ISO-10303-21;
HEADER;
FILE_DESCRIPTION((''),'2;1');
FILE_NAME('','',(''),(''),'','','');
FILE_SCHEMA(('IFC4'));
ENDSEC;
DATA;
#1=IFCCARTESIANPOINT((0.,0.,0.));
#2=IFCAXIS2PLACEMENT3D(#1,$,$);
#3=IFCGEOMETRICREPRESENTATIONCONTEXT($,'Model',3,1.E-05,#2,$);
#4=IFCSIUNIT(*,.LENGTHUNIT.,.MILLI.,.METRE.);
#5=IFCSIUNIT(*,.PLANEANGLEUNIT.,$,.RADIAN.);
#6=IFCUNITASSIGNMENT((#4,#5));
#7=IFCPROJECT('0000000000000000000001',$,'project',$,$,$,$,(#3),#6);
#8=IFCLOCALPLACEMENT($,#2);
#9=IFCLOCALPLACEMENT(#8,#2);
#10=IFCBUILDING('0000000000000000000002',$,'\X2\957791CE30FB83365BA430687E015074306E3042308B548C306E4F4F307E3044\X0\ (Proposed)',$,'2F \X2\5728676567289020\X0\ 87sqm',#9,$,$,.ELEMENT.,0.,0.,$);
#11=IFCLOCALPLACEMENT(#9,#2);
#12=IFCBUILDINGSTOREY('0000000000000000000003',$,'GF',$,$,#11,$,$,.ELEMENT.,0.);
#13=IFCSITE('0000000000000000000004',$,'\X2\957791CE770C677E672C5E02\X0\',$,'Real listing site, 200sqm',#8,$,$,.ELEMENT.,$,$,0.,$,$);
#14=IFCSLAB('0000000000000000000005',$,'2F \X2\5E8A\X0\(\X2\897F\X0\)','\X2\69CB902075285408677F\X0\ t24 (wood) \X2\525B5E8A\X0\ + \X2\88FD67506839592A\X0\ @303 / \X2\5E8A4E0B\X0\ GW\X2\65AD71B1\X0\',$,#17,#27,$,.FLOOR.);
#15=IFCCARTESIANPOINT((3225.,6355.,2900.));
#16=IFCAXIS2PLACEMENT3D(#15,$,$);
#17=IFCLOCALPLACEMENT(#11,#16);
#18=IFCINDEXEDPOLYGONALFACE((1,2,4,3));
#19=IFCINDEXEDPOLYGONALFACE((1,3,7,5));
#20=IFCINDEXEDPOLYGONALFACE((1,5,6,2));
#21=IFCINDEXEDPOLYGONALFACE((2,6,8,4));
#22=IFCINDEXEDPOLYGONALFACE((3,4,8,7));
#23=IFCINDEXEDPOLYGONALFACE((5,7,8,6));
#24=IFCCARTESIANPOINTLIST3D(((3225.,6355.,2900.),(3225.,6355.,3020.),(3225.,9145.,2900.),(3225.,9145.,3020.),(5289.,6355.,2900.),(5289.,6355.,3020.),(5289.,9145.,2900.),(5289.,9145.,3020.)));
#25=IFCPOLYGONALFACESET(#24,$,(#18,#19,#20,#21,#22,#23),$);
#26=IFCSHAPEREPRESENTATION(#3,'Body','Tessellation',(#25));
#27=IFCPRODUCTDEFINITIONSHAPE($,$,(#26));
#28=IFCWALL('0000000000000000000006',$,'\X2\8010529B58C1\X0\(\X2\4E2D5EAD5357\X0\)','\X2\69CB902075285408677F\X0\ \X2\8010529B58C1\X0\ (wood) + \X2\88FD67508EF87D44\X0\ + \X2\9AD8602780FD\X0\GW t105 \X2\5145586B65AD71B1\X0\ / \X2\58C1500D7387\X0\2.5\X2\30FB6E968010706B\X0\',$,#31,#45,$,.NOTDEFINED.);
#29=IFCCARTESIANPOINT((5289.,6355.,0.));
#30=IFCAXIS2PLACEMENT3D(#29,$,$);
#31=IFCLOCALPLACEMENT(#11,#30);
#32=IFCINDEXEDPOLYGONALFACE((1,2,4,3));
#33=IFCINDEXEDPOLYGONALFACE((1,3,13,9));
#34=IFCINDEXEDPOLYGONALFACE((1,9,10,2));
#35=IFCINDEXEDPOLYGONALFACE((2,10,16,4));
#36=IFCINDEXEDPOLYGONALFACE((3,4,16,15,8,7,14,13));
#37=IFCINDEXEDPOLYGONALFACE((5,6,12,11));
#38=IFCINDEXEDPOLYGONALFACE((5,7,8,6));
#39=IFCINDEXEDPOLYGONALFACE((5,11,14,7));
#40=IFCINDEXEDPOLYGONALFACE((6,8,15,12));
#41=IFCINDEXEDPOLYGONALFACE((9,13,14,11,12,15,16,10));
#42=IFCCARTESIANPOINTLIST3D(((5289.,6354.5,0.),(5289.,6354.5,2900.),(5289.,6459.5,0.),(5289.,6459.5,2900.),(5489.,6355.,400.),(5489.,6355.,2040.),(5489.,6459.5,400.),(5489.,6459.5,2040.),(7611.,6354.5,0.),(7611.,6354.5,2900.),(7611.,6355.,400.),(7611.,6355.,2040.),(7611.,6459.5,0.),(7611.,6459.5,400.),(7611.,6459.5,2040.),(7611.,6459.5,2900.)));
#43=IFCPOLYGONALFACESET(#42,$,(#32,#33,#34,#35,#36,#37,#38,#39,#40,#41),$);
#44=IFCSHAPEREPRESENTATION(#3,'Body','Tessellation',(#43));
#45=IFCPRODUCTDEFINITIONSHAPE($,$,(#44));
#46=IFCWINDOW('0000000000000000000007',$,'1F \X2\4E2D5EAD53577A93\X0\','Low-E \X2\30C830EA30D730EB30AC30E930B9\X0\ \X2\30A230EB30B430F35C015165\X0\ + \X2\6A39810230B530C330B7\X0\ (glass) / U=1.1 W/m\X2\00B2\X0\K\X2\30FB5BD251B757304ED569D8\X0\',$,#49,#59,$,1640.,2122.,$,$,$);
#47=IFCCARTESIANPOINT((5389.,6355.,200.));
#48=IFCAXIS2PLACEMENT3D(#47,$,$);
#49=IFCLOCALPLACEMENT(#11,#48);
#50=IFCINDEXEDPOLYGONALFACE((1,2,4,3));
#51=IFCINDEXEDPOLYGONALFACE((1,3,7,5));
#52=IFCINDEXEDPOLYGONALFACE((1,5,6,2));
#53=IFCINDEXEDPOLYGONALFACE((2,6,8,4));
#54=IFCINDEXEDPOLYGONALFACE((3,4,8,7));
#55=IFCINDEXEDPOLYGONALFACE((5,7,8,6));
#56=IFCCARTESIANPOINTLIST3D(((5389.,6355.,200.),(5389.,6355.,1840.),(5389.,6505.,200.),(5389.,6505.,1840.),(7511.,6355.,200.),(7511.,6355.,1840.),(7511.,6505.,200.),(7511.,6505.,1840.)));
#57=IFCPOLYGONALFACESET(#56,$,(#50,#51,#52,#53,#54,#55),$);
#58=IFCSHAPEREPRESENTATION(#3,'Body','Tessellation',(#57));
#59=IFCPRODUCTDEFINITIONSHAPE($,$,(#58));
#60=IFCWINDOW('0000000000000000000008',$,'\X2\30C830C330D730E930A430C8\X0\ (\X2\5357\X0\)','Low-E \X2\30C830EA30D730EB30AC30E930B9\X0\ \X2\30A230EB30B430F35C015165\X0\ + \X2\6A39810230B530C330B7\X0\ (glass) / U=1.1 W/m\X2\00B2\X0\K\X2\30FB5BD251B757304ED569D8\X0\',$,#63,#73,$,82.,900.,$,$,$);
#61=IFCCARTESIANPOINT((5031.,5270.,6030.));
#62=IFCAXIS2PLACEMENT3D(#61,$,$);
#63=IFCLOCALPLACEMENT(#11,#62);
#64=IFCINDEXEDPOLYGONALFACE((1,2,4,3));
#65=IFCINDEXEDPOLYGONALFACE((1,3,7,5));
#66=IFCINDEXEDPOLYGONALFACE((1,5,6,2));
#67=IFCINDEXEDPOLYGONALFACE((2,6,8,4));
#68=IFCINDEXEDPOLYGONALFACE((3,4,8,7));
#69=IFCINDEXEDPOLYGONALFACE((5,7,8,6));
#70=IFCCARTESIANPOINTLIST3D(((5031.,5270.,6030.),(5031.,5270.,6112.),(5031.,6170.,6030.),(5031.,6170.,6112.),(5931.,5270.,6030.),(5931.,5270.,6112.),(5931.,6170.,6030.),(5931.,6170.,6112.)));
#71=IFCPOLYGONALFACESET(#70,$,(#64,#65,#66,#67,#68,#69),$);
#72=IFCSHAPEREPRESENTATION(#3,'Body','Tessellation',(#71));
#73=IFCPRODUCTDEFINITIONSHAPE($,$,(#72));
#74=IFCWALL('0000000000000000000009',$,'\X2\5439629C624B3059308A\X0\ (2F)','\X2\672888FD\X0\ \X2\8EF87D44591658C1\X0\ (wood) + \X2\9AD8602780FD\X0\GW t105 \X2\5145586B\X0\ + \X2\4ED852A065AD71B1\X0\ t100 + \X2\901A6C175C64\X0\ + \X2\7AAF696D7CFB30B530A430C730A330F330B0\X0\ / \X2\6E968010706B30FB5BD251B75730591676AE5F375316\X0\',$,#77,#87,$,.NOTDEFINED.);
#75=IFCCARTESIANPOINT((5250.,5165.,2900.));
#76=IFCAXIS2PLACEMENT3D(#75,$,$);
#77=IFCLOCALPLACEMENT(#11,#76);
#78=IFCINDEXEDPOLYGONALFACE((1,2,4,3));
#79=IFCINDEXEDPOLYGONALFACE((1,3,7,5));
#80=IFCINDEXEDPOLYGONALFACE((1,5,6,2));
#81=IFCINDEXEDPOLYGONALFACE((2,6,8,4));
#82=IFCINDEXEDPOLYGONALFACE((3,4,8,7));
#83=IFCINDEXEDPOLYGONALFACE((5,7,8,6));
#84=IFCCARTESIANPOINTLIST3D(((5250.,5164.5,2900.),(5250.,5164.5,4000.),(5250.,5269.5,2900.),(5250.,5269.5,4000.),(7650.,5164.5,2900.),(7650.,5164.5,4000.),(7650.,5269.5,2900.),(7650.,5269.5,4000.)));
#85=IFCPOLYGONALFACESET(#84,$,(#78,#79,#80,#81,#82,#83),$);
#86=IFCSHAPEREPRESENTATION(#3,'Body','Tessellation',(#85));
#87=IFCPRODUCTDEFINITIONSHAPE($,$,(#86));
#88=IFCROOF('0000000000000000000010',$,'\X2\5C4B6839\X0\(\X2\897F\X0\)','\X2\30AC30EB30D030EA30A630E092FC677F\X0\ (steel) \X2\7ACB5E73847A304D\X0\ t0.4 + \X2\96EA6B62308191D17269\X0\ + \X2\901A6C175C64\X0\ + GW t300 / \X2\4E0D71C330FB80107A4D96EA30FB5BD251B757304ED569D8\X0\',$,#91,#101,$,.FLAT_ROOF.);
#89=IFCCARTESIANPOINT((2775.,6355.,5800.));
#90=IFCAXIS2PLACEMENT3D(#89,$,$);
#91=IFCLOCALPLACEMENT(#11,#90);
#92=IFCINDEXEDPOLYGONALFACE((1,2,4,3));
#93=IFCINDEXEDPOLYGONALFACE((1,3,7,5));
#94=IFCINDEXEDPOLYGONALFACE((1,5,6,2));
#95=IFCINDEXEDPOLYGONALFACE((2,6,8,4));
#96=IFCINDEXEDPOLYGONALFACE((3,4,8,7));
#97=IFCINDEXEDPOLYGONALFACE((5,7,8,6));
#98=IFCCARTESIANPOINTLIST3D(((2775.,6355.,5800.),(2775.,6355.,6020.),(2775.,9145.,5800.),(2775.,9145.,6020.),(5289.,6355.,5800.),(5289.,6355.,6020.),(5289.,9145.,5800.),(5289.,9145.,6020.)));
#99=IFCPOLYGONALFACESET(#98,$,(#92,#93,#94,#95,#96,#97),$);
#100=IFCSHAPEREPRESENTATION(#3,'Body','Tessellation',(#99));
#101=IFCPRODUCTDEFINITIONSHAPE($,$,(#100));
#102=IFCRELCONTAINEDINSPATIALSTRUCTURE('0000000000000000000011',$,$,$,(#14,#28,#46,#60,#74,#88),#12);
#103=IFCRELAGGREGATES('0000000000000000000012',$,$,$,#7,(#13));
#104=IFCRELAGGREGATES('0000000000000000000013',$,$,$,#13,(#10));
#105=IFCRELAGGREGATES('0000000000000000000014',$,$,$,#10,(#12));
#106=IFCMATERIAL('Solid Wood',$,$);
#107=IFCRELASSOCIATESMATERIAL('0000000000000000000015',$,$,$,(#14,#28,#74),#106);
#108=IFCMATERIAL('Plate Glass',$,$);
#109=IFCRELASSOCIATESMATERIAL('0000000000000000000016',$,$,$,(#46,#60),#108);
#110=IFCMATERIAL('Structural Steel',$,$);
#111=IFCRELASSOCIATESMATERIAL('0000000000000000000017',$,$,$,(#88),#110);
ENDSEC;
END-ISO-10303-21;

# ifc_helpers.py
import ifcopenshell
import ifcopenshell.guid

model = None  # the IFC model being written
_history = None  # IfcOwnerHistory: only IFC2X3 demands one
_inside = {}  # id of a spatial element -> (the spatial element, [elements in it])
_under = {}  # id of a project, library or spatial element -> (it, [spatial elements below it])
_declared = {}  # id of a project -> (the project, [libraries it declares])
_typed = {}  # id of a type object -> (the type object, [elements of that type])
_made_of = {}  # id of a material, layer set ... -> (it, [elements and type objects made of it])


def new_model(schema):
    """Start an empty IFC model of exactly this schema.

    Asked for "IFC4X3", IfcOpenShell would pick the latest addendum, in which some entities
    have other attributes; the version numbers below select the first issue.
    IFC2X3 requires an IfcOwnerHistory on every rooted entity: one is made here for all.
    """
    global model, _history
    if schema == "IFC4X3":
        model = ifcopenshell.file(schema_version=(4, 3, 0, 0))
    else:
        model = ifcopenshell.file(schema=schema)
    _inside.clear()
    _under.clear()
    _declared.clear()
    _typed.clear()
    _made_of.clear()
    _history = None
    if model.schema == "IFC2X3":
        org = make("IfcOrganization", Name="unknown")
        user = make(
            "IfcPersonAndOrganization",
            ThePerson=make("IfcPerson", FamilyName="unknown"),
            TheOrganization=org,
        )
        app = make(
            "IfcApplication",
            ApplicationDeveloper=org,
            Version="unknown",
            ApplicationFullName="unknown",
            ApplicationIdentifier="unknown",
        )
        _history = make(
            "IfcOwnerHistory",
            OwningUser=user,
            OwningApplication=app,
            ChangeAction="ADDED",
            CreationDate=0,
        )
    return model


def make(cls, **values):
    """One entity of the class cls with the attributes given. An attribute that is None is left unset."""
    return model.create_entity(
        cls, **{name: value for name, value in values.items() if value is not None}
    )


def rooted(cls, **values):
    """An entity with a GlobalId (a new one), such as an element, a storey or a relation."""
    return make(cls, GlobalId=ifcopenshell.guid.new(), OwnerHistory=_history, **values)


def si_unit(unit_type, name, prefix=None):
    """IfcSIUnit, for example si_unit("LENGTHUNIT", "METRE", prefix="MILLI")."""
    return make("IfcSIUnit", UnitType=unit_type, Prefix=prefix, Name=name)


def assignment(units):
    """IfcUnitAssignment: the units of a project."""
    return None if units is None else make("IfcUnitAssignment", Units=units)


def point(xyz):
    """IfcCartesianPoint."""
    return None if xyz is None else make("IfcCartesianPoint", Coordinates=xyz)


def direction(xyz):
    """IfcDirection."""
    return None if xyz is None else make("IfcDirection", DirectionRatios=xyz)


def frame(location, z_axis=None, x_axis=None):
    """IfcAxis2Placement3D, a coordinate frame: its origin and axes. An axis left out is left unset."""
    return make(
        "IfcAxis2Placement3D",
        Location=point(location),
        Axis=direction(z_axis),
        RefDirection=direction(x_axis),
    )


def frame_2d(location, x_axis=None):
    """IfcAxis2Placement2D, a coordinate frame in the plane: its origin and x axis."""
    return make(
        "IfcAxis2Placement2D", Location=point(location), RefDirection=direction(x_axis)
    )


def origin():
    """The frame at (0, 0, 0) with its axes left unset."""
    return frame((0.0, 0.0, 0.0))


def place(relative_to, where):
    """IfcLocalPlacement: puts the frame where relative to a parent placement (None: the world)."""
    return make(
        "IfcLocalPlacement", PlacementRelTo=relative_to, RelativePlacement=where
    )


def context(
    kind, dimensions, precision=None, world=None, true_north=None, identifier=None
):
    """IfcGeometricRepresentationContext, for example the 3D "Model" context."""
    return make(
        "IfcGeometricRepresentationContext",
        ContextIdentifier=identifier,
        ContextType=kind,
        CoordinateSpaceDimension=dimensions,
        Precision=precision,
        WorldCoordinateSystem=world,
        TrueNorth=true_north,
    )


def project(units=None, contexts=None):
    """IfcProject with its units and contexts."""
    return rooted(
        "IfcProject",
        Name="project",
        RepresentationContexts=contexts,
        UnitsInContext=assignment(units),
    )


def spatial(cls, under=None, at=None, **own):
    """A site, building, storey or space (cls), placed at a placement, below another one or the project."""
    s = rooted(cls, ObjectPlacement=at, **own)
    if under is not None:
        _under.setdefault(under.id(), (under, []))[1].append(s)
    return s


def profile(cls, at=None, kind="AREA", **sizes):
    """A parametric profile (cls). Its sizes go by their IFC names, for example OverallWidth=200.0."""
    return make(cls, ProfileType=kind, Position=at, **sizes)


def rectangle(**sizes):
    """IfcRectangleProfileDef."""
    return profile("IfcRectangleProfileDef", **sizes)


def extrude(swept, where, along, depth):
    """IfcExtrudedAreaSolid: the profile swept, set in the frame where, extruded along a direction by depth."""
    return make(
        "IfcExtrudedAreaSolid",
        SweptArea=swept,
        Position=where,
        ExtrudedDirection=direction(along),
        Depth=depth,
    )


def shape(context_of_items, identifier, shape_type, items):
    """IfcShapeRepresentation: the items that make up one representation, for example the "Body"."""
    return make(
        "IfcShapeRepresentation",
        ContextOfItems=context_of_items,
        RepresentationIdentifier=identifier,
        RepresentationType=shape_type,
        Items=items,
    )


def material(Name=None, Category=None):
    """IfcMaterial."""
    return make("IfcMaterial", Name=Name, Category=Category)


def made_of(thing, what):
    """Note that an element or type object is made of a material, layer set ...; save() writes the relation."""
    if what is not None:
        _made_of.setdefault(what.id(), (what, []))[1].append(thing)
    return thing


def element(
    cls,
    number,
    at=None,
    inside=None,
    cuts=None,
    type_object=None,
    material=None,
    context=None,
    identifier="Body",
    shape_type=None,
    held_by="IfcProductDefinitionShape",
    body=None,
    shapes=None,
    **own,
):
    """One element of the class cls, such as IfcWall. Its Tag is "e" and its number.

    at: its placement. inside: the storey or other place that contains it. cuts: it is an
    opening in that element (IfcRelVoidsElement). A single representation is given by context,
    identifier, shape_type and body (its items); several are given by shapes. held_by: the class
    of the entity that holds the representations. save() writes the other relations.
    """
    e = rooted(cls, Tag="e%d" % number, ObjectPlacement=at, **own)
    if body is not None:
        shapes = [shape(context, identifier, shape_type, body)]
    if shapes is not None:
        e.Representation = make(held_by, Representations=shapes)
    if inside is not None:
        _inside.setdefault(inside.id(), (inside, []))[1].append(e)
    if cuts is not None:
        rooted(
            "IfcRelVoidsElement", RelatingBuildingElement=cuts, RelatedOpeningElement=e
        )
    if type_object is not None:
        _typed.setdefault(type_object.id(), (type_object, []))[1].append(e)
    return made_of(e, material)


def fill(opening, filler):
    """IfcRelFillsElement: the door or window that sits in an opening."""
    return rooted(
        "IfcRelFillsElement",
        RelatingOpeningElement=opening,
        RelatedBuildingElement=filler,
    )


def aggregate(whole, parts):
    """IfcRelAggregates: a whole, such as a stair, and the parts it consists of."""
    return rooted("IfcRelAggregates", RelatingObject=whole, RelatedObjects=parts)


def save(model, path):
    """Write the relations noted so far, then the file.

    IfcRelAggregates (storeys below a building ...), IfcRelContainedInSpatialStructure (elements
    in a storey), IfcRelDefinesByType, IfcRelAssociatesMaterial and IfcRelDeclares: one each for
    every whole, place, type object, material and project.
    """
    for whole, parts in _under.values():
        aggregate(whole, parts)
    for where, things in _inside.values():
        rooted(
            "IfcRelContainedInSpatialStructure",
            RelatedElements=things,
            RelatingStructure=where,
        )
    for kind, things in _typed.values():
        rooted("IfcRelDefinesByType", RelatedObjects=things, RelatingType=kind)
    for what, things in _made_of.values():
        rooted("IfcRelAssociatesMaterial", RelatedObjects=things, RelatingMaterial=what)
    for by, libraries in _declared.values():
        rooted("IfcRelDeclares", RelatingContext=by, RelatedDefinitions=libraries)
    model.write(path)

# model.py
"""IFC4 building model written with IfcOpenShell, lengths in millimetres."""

from ifc_helpers import new_model, si_unit, frame, frame_2d, origin, place, context, project, spatial, rectangle, extrude, material, element, fill, save


model = new_model("IFC4")

# Units and contexts
model_context = context("Model", 3, precision=1e-05, world=origin())
ifc_project = project(units=[si_unit("LENGTHUNIT", "METRE", prefix="MILLI"), si_unit("PLANEANGLEUNIT", "RADIAN")], contexts=[model_context])

# Site, building, storey
site_placement = place(None, origin())
site = spatial("IfcSite", under=ifc_project, at=site_placement, Name="長野県松本市", ObjectType="Real listing site, 200sqm", CompositionType="ELEMENT", RefElevation=0.0)
building_placement = place(site_placement, origin())
building = spatial("IfcBuilding", under=site, at=building_placement, Name="長野・茶室と縁側のある和の住まい (Proposed)", ObjectType="2F 在来木造 87sqm", CompositionType="ELEMENT", ElevationOfRefHeight=0.0, ElevationOfTerrain=0.0)
storey_placement = place(building_placement, origin())
storey = spatial("IfcBuildingStorey", under=building, at=storey_placement, Name="GF", CompositionType="ELEMENT", Elevation=0.0)

# Shared definitions
ifc_material_1 = material(Name="Solid Wood")

# Slab
slab_1_placement = place(storey_placement, frame((3225.0, 6355.0, 2900.0)))
element("IfcSlab", 1, at=slab_1_placement, inside=storey, material=ifc_material_1, Name="2F 床(西)", Description="構造用合板 t24 (wood) 剛床 + 製材根太 @303 / 床下 GW断熱", PredefinedType="FLOOR", context=model_context, shape_type="SweptSolid", body=[
    extrude(rectangle(XDim=2064.0, YDim=2790.0, at=frame_2d((1032.0, 1395.0))), frame((3225.0, 6355.0, 2900.0)), (0.0, 0.0, 1.0), 120.0),
])

# Wall, opening, window
wall_1_placement = place(storey_placement, frame((5289.0, 6355.0, 0.0)))
wall_1 = element("IfcWall", 2, at=wall_1_placement, inside=storey, material=ifc_material_1, Name="耐力壁(中庭南)", Description="構造用合板 耐力壁 (wood) + 製材軸組 + 高性能GW t105 充填断熱 / 壁倍率2.5・準耐火", PredefinedType="NOTDEFINED", context=model_context, shape_type="SweptSolid", body=[
    extrude(rectangle(XDim=2322.0, YDim=105.0, at=frame_2d((1161.0, 52.0))), frame((5289.0, 6355.0, 0.0)), (0.0, 0.0, 1.0), 2900.0),
])
opening_placement = place(storey_placement, frame((5389.0, 6355.0, 200.0)))
opening = element("IfcOpeningElement", 3, at=opening_placement, cuts=wall_1, PredefinedType="NOTDEFINED", context=model_context, shape_type="SweptSolid", body=[
    extrude(rectangle(XDim=2122.0, YDim=150.0, at=frame_2d((1061.0, 75.0))), frame((5389.0, 6355.0, 200.0)), (0.0, 0.0, 1.0), 1640.0),
])
ifc_material_2 = material(Name="Plate Glass")
window_1_placement = place(storey_placement, frame((5389.0, 6355.0, 200.0)))
window_1 = element("IfcWindow", 4, at=window_1_placement, inside=storey, material=ifc_material_2, Name="1F 中庭南窓", Description="Low-E トリプルガラス アルゴン封入 + 樹脂サッシ (glass) / U=1.1 W/m²K・寒冷地仕様", OverallHeight=1640.0, OverallWidth=2122.0, context=model_context, shape_type="SweptSolid", body=[
    extrude(rectangle(XDim=2122.0, YDim=150.0, at=frame_2d((1061.0, 75.0))), frame((5389.0, 6355.0, 200.0)), (0.0, 0.0, 1.0), 1640.0),
])
fill(opening, window_1)

# Window
window_2_placement = place(storey_placement, frame((5031.0, 5270.0, 6030.0)))
element("IfcWindow", 5, at=window_2_placement, inside=storey, material=ifc_material_2, Name="トップライト (南)", Description="Low-E トリプルガラス アルゴン封入 + 樹脂サッシ (glass) / U=1.1 W/m²K・寒冷地仕様", OverallHeight=82.0, OverallWidth=900.0, context=model_context, shape_type="SweptSolid", body=[
    extrude(rectangle(XDim=900.0, YDim=900.0, at=frame_2d((450.0, 450.0))), frame((5031.0, 5270.0, 6030.0)), (0.0, 0.0, 1.0), 82.0),
])

# Wall
wall_2_placement = place(storey_placement, frame((5250.0, 5165.0, 2900.0)))
element("IfcWall", 6, at=wall_2_placement, inside=storey, material=ifc_material_1, Name="吹抜手すり (2F)", Description="木製 軸組外壁 (wood) + 高性能GW t105 充填 + 付加断熱 t100 + 通気層 + 窯業系サイディング / 準耐火・寒冷地外皮強化", PredefinedType="NOTDEFINED", context=model_context, shape_type="SweptSolid", body=[
    extrude(rectangle(XDim=2400.0, YDim=105.0, at=frame_2d((1200.0, 52.0))), frame((5250.0, 5165.0, 2900.0)), (0.0, 0.0, 1.0), 1100.0),
])

# Roof
ifc_material_3 = material(Name="Structural Steel")
for number, where, name in (
    (7, (2775.0, 6355.0, 5800.0), "屋根(西)"),
):
    element("IfcRoof", number, at=place(storey_placement, frame(where)), inside=storey, material=ifc_material_3, Name=name, Description="ガルバリウム鋼板 (steel) 立平葺き t0.4 + 雪止め金物 + 通気層 + GW t300 / 不燃・耐積雪・寒冷地仕様", PredefinedType="FLAT_ROOF", context=model_context, shape_type="SweptSolid", body=[
        extrude(rectangle(XDim=2514.0, YDim=2790.0, at=frame_2d((1257.0, 1395.0))), frame((2775.0, 6355.0, 5800.0)), (0.0, 0.0, 1.0), 220.0),
    ])

save(model, "model.ifc")
